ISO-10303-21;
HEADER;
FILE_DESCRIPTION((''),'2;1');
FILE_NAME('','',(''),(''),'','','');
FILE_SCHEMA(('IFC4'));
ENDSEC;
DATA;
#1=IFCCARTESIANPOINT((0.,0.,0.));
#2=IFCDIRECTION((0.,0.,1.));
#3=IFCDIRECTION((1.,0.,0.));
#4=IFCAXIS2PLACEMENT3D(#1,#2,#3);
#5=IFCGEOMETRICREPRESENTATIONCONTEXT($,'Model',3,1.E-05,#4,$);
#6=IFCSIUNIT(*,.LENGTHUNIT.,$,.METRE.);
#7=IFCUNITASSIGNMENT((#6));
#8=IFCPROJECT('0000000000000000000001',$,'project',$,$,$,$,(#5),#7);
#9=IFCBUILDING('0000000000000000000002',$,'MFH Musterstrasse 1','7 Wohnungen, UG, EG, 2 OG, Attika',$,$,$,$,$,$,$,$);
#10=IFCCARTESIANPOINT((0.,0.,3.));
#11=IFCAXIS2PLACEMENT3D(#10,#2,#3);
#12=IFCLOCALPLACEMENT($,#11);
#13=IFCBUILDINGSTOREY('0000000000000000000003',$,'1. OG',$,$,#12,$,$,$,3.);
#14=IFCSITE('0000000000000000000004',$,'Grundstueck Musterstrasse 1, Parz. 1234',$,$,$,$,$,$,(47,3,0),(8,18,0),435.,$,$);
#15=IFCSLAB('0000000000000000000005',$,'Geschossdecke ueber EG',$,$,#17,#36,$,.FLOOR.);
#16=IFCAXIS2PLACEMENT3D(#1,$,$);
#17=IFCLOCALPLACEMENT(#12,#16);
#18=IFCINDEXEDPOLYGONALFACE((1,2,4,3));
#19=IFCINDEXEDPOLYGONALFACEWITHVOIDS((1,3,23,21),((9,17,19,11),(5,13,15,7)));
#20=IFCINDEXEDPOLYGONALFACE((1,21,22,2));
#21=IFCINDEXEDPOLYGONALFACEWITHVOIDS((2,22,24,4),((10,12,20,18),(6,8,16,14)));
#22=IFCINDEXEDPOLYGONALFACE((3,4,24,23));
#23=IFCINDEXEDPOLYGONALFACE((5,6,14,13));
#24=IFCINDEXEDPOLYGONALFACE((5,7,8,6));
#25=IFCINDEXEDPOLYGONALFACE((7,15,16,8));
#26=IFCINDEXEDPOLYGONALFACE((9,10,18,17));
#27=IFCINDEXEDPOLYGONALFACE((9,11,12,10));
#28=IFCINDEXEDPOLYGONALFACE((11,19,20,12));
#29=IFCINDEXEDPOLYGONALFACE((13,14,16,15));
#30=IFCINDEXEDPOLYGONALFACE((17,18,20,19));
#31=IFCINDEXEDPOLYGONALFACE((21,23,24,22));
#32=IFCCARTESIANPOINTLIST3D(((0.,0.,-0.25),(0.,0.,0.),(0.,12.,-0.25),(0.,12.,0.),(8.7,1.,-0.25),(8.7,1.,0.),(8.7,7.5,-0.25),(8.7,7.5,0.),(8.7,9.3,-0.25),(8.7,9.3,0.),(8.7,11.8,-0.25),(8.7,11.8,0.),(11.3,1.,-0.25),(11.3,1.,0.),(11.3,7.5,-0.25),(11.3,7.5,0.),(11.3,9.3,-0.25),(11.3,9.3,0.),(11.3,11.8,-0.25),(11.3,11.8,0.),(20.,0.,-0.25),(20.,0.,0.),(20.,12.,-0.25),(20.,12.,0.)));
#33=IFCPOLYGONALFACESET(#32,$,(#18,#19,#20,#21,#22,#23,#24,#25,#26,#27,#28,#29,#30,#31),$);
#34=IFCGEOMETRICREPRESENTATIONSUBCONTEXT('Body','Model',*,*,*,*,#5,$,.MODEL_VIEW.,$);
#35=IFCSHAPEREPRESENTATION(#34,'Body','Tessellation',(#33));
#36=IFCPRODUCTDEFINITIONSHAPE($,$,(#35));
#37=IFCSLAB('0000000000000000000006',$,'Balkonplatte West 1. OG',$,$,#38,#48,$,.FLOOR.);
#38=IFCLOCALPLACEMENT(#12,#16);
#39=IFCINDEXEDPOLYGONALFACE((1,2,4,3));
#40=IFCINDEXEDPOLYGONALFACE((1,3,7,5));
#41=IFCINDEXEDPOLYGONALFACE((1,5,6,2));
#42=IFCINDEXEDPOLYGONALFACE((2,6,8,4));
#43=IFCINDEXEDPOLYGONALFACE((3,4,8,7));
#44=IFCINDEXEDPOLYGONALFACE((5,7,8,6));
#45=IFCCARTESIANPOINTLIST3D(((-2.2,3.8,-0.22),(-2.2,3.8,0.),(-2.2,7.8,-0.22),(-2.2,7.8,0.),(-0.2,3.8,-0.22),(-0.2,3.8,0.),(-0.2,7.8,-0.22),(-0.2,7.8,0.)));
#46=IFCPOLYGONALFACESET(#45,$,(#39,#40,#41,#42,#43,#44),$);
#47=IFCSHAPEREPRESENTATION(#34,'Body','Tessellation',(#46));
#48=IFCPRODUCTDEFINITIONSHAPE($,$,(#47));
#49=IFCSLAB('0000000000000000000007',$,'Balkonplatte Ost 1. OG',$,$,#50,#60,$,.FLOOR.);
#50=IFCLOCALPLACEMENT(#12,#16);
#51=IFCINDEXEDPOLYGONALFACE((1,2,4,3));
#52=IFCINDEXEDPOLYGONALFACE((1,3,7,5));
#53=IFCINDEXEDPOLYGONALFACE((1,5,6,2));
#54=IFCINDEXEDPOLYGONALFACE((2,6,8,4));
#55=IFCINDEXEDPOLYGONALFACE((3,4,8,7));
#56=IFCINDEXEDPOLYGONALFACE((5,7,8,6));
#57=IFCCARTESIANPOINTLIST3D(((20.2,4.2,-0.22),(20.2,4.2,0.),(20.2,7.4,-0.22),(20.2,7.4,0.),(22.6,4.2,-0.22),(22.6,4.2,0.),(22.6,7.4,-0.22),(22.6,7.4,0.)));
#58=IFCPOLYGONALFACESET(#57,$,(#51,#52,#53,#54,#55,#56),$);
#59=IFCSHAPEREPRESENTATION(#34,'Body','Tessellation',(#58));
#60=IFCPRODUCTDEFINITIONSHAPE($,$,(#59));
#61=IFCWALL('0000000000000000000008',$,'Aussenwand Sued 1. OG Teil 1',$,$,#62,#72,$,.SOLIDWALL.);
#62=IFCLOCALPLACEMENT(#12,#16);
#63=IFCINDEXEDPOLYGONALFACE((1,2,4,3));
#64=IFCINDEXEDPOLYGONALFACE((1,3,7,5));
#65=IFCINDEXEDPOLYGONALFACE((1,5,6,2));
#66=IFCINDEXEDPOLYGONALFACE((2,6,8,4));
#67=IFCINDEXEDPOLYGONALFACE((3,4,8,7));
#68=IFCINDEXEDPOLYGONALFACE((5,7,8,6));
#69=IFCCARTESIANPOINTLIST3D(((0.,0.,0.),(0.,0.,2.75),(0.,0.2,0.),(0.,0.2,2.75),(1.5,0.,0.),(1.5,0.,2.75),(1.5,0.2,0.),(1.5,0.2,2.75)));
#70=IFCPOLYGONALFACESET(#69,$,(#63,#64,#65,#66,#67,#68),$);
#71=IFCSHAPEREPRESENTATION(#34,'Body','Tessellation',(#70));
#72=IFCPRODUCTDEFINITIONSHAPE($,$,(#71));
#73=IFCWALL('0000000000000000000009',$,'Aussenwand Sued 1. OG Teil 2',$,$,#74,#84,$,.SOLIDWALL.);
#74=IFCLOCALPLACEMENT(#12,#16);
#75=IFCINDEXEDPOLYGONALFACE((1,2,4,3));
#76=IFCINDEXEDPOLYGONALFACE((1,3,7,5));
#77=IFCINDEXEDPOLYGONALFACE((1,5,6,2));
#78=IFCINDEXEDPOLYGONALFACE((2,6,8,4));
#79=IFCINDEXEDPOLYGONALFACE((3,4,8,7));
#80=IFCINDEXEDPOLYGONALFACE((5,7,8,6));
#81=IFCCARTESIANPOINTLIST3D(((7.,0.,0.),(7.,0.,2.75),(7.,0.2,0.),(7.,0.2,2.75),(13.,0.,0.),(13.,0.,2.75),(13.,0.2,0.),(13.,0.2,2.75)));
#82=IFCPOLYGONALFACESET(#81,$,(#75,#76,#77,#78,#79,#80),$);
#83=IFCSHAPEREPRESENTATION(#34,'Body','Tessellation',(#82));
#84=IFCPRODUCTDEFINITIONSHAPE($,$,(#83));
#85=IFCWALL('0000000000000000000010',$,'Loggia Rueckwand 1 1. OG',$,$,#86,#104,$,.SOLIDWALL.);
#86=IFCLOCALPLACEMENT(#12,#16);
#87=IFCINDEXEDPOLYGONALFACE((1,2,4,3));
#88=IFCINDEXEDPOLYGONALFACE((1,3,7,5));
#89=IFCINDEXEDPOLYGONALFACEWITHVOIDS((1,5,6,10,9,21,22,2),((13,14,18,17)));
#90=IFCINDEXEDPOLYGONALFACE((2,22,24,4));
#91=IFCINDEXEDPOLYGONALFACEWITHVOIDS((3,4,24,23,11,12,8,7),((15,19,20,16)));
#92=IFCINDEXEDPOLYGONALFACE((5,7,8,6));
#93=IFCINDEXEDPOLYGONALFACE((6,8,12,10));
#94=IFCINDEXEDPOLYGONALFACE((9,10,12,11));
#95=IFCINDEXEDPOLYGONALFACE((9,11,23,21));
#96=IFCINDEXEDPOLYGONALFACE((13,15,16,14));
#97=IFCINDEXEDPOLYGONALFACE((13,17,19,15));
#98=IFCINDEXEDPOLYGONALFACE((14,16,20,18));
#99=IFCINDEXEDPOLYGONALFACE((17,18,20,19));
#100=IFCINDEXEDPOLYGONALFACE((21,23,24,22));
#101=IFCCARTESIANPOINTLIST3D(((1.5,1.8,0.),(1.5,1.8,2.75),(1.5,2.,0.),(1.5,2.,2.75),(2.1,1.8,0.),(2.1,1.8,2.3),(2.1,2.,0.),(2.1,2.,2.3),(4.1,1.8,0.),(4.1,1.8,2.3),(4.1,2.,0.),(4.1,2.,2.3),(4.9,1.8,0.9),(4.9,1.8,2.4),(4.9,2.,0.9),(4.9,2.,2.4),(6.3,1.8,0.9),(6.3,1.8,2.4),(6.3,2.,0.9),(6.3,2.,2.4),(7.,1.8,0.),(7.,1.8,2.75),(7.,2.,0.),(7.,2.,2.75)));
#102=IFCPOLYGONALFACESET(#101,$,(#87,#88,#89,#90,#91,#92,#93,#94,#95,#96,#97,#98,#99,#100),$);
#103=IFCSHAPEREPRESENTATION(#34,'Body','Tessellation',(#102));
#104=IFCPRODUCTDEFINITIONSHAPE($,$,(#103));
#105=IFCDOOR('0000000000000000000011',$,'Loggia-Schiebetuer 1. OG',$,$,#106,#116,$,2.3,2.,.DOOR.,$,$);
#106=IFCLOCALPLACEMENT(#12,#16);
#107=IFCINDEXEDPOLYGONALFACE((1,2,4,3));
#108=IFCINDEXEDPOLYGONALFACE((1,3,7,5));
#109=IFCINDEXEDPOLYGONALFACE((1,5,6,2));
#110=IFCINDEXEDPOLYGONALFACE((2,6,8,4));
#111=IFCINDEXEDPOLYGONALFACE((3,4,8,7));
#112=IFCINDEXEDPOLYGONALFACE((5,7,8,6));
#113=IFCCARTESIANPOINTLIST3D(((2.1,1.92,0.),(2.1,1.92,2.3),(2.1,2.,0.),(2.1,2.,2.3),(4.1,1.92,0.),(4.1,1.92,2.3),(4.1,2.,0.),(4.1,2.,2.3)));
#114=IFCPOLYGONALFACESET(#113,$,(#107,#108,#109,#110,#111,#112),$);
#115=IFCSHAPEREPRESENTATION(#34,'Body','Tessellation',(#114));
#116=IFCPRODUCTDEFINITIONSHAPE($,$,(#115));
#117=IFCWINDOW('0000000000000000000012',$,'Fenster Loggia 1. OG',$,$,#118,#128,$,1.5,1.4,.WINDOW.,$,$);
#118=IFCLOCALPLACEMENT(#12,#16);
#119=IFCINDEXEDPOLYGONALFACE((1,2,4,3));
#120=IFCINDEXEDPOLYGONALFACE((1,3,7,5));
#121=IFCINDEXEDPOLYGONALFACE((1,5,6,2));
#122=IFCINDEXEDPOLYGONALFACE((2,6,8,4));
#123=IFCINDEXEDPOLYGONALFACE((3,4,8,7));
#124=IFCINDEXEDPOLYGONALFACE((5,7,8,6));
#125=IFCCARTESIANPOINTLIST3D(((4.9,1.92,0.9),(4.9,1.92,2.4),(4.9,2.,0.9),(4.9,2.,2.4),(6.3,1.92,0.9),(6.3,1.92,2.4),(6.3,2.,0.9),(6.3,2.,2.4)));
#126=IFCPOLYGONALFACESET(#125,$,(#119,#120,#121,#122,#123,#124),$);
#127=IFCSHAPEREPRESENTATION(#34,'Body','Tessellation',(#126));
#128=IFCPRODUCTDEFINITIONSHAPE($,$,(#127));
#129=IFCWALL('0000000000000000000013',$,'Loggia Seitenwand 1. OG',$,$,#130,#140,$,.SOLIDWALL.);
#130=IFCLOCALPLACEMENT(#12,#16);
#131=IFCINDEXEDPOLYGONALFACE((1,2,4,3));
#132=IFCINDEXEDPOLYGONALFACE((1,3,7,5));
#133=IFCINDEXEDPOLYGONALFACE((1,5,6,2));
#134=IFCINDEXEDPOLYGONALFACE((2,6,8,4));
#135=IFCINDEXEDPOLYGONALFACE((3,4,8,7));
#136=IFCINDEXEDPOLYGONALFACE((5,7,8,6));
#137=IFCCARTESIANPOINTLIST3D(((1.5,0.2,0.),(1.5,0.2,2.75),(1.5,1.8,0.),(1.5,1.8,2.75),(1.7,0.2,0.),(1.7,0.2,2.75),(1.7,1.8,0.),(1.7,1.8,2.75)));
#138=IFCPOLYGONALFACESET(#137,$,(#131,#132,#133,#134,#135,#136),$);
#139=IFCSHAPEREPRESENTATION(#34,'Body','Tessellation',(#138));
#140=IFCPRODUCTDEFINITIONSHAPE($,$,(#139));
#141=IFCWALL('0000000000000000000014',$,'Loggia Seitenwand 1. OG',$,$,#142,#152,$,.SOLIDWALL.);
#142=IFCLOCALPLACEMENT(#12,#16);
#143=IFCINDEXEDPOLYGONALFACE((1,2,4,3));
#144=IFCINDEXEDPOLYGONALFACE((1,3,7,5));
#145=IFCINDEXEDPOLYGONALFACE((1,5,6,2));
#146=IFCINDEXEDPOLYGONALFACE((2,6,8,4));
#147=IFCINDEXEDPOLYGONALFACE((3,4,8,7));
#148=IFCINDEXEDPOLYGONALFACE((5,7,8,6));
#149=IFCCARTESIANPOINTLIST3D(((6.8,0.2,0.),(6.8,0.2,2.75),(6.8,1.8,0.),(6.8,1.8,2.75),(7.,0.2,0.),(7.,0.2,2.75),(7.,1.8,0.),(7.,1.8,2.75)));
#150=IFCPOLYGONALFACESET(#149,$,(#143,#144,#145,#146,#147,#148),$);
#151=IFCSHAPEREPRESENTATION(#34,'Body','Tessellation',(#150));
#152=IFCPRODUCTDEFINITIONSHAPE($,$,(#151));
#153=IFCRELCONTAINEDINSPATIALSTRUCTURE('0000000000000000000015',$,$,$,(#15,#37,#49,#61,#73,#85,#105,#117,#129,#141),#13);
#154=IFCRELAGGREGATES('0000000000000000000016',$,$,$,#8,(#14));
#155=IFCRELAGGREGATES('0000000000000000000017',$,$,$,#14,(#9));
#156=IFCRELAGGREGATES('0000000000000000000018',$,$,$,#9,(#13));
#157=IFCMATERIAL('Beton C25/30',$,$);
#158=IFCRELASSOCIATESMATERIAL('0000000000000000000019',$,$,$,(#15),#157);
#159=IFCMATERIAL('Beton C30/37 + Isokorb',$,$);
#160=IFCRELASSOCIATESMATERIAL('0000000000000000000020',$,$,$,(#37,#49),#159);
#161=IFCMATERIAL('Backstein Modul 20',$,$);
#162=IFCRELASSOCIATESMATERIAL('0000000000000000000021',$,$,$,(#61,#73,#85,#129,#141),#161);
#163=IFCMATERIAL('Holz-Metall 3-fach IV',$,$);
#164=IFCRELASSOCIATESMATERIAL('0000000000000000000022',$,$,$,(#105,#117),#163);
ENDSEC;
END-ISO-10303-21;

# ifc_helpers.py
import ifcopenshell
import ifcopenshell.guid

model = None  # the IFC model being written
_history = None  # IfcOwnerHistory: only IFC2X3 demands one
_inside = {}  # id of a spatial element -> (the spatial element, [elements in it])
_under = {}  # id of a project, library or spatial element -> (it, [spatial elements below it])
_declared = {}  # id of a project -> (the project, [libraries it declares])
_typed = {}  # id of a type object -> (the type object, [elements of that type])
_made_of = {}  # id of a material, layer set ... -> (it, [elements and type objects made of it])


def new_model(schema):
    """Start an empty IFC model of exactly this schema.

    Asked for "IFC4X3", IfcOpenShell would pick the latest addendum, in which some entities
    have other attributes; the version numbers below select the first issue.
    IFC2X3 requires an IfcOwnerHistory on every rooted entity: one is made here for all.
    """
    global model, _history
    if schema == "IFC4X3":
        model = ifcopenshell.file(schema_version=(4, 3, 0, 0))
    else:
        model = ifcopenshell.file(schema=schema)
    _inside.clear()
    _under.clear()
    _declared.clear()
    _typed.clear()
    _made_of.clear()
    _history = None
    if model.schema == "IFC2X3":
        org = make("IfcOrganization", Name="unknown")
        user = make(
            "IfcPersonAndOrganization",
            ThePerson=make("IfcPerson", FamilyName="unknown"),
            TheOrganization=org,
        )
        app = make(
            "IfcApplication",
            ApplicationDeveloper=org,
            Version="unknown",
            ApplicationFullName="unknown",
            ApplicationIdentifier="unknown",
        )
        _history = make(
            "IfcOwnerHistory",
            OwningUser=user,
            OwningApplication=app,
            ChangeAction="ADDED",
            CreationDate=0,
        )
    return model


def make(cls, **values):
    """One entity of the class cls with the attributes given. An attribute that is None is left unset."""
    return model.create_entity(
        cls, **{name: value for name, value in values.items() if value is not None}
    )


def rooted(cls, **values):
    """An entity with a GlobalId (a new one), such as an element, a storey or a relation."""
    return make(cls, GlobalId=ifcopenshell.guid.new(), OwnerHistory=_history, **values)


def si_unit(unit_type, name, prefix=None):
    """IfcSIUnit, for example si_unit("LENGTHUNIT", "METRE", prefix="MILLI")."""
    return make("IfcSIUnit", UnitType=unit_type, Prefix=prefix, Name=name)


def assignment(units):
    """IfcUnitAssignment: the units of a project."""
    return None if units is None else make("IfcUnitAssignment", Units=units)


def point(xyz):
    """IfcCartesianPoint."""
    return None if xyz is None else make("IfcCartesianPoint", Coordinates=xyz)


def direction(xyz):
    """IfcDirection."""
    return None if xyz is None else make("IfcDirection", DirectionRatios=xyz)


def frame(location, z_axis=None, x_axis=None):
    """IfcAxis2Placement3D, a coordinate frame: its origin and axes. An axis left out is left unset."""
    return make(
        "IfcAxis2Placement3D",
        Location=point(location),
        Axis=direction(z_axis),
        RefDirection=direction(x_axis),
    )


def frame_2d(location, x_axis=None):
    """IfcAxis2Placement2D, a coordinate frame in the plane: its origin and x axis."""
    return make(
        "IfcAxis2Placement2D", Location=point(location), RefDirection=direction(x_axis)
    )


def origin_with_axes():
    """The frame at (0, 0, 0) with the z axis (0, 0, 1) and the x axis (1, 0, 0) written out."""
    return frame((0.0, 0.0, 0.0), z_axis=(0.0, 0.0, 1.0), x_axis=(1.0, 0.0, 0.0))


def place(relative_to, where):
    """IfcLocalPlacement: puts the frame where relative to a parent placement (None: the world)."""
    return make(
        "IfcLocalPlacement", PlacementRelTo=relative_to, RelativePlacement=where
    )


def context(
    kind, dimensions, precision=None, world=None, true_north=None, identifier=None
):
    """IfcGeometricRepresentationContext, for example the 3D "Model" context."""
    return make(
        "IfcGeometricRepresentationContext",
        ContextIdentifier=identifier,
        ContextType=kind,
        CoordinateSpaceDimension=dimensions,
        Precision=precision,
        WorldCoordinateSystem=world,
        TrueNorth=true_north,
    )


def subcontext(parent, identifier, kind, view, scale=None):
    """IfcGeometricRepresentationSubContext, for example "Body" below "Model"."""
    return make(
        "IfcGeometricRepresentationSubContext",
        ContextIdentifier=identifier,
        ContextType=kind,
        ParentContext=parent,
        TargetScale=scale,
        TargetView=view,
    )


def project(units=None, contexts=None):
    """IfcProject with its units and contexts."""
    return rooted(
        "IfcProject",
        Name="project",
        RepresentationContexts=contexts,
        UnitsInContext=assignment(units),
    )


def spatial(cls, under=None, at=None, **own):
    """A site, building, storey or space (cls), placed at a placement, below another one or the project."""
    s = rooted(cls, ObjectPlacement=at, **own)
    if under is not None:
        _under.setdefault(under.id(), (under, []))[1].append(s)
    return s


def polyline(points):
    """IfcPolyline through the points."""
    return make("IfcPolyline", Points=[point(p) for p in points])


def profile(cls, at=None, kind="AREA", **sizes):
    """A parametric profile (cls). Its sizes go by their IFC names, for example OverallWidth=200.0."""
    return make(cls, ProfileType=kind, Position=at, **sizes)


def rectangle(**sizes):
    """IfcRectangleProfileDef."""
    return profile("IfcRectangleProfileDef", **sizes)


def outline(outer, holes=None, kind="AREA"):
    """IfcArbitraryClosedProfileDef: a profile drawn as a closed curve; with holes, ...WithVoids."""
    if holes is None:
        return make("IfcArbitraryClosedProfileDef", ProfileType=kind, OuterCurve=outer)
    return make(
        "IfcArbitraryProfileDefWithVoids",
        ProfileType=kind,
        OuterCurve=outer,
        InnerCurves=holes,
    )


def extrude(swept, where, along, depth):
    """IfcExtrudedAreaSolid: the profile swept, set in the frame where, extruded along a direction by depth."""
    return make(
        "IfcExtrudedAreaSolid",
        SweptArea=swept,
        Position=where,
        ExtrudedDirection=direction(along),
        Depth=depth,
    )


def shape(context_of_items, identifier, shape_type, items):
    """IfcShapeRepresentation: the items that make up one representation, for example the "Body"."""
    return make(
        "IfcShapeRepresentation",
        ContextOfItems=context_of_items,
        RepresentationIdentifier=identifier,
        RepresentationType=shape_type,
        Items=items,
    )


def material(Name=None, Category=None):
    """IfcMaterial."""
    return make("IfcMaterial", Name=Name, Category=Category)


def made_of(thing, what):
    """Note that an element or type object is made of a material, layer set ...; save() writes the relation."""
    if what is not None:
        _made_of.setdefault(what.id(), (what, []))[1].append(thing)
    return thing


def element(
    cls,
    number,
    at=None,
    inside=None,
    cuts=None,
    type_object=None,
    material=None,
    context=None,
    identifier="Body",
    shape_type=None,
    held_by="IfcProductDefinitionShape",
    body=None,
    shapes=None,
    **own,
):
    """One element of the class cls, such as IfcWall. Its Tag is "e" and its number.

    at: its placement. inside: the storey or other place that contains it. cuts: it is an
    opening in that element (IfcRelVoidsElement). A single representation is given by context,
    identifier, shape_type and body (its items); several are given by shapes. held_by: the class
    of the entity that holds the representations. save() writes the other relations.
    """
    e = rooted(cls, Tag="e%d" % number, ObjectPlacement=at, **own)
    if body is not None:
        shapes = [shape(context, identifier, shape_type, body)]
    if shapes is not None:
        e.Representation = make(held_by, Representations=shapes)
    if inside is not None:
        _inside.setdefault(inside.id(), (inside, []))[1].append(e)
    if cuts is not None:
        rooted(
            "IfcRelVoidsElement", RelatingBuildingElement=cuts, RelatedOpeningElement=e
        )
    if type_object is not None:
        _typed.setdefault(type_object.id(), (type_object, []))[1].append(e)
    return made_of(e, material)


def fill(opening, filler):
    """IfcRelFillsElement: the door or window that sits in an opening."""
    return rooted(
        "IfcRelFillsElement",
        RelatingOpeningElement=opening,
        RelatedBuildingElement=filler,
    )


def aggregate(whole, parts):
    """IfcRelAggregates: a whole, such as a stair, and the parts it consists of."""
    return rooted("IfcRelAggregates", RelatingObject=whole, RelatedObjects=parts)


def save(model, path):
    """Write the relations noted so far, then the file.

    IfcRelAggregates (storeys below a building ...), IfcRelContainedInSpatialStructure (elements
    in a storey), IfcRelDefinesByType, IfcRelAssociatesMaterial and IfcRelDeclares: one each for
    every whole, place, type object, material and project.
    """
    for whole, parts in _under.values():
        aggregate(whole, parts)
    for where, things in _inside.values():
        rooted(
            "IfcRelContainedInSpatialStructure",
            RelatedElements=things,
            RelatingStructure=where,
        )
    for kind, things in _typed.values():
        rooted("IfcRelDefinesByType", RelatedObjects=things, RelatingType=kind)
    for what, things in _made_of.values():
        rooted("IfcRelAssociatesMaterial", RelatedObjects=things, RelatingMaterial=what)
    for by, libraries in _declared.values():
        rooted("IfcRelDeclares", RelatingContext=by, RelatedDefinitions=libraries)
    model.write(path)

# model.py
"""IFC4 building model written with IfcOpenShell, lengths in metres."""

from ifc_helpers import new_model, si_unit, frame, frame_2d, origin_with_axes, place, context, subcontext, project, spatial, polyline, rectangle, outline, extrude, material, element, fill, save


model = new_model("IFC4")

# Units and contexts
model_context = context("Model", 3, precision=1e-05, world=origin_with_axes())
body_context = subcontext(model_context, "Body", "Model", "MODEL_VIEW")
ifc_project = project(units=[si_unit("LENGTHUNIT", "METRE")], contexts=[model_context])

# Site, building, storey
site = spatial("IfcSite", under=ifc_project, Name="Grundstueck Musterstrasse 1, Parz. 1234", RefLatitude=(47, 3, 0), RefLongitude=(8, 18, 0), RefElevation=435.0)
building = spatial("IfcBuilding", under=site, Name="MFH Musterstrasse 1", Description="7 Wohnungen, UG, EG, 2 OG, Attika")
storey_placement = place(None, frame((0.0, 0.0, 3.0), z_axis=(0.0, 0.0, 1.0), x_axis=(1.0, 0.0, 0.0)))
storey = spatial("IfcBuildingStorey", under=building, at=storey_placement, Name="1. OG", Elevation=3.0)

# Slab, openings
ifc_material_1 = material(Name="Beton C25/30")
slab_1_placement = place(storey_placement, frame((0.0, 0.0, -0.25), z_axis=(0.0, 0.0, 1.0), x_axis=(1.0, 0.0, 0.0)))
slab_1 = element("IfcSlab", 1, at=slab_1_placement, inside=storey, material=ifc_material_1, Name="Geschossdecke ueber EG", PredefinedType="FLOOR", context=body_context, shape_type="SweptSolid", body=[
    extrude(outline(polyline([(0.0, 0.0), (20.0, 0.0), (20.0, 12.0), (0.0, 12.0), (0.0, 0.0)])), origin_with_axes(), (0.0, 0.0, 1.0), 0.25),
])
opening_1_placement = place(slab_1_placement, frame((8.7, 1.0, -0.01), z_axis=(0.0, 0.0, 1.0), x_axis=(1.0, 0.0, 0.0)))
element("IfcOpeningElement", 2, at=opening_1_placement, cuts=slab_1, context=body_context, shape_type="SweptSolid", body=[
    extrude(rectangle(XDim=2.6, YDim=6.5, at=frame_2d((1.3, 3.25))), origin_with_axes(), (0.0, 0.0, 1.0), 0.27),
])
opening_2_placement = place(slab_1_placement, frame((8.7, 9.3, -0.01), z_axis=(0.0, 0.0, 1.0), x_axis=(1.0, 0.0, 0.0)))
element("IfcOpeningElement", 3, at=opening_2_placement, cuts=slab_1, context=body_context, shape_type="SweptSolid", body=[
    extrude(rectangle(XDim=2.6, YDim=2.5, at=frame_2d((1.3, 1.25))), origin_with_axes(), (0.0, 0.0, 1.0), 0.27),
])

# Slabs
ifc_material_2 = material(Name="Beton C30/37 + Isokorb")
slab_2_placement = place(storey_placement, frame((0.0, 0.0, -0.22), z_axis=(0.0, 0.0, 1.0), x_axis=(1.0, 0.0, 0.0)))
element("IfcSlab", 4, at=slab_2_placement, inside=storey, material=ifc_material_2, Name="Balkonplatte West 1. OG", PredefinedType="FLOOR", context=body_context, shape_type="SweptSolid", body=[
    extrude(outline(polyline([(-2.2, 3.8), (-0.2, 3.8), (-0.2, 7.8), (-2.2, 7.8), (-2.2, 3.8)])), origin_with_axes(), (0.0, 0.0, 1.0), 0.22),
])
slab_3_placement = place(storey_placement, frame((0.0, 0.0, -0.22), z_axis=(0.0, 0.0, 1.0), x_axis=(1.0, 0.0, 0.0)))
element("IfcSlab", 5, at=slab_3_placement, inside=storey, material=ifc_material_2, Name="Balkonplatte Ost 1. OG", PredefinedType="FLOOR", context=body_context, shape_type="SweptSolid", body=[
    extrude(outline(polyline([(20.2, 4.2), (22.6, 4.2), (22.6, 7.4), (20.2, 7.4), (20.2, 4.2)])), origin_with_axes(), (0.0, 0.0, 1.0), 0.22),
])

# Walls
ifc_material_3 = material(Name="Backstein Modul 20")
wall_1_placement = place(storey_placement, origin_with_axes())
element("IfcWall", 6, at=wall_1_placement, inside=storey, material=ifc_material_3, Name="Aussenwand Sued 1. OG Teil 1", PredefinedType="SOLIDWALL", context=body_context, shape_type="SweptSolid", body=[
    extrude(rectangle(XDim=1.5, YDim=0.2, at=frame_2d((0.75, 0.1))), origin_with_axes(), (0.0, 0.0, 1.0), 2.75),
])
wall_2_placement = place(storey_placement, frame((7.0, 0.0, 0.0), z_axis=(0.0, 0.0, 1.0), x_axis=(1.0, 0.0, 0.0)))
element("IfcWall", 7, at=wall_2_placement, inside=storey, material=ifc_material_3, Name="Aussenwand Sued 1. OG Teil 2", PredefinedType="SOLIDWALL", context=body_context, shape_type="SweptSolid", body=[
    extrude(rectangle(XDim=6.0, YDim=0.2, at=frame_2d((3.0, 0.1))), origin_with_axes(), (0.0, 0.0, 1.0), 2.75),
])

# Wall, openings, door, window
wall_3_placement = place(storey_placement, frame((1.5, 1.8, 0.0), z_axis=(0.0, 0.0, 1.0), x_axis=(1.0, 0.0, 0.0)))
wall_3 = element("IfcWall", 8, at=wall_3_placement, inside=storey, material=ifc_material_3, Name="Loggia Rueckwand 1 1. OG", PredefinedType="SOLIDWALL", context=body_context, shape_type="SweptSolid", body=[
    extrude(rectangle(XDim=5.5, YDim=0.2, at=frame_2d((2.75, 0.1))), origin_with_axes(), (0.0, 0.0, 1.0), 2.75),
])
opening_3_placement = place(wall_3_placement, frame((0.6, -0.21, 0.0), z_axis=(0.0, 0.0, 1.0), x_axis=(1.0, 0.0, 0.0)))
opening_3 = element("IfcOpeningElement", 9, at=opening_3_placement, cuts=wall_3, context=body_context, shape_type="SweptSolid", body=[
    extrude(rectangle(XDim=2.0, YDim=0.42, at=frame_2d((1.0, 0.21))), origin_with_axes(), (0.0, 0.0, 1.0), 2.3),
])
opening_4_placement = place(wall_3_placement, frame((3.4, -0.21, 0.9), z_axis=(0.0, 0.0, 1.0), x_axis=(1.0, 0.0, 0.0)))
opening_4 = element("IfcOpeningElement", 10, at=opening_4_placement, cuts=wall_3, context=body_context, shape_type="SweptSolid", body=[
    extrude(rectangle(XDim=1.4, YDim=0.42, at=frame_2d((0.7, 0.21))), origin_with_axes(), (0.0, 0.0, 1.0), 1.5),
])
ifc_material_4 = material(Name="Holz-Metall 3-fach IV")
door_1_placement = place(storey_placement, frame((2.1, 1.92, 0.0), z_axis=(0.0, 0.0, 1.0), x_axis=(1.0, 0.0, 0.0)))
door_1 = element("IfcDoor", 11, at=door_1_placement, inside=storey, material=ifc_material_4, Name="Loggia-Schiebetuer 1. OG", OverallHeight=2.3, OverallWidth=2.0, PredefinedType="DOOR", context=body_context, shape_type="SweptSolid", body=[
    extrude(rectangle(XDim=2.0, YDim=0.08, at=frame_2d((1.0, 0.04))), origin_with_axes(), (0.0, 0.0, 1.0), 2.3),
])
fill(opening_3, door_1)
window_1_placement = place(storey_placement, frame((4.9, 1.92, 0.9), z_axis=(0.0, 0.0, 1.0), x_axis=(1.0, 0.0, 0.0)))
window_1 = element("IfcWindow", 12, at=window_1_placement, inside=storey, material=ifc_material_4, Name="Fenster Loggia 1. OG", OverallHeight=1.5, OverallWidth=1.4, PredefinedType="WINDOW", context=body_context, shape_type="SweptSolid", body=[
    extrude(rectangle(XDim=1.4, YDim=0.08, at=frame_2d((0.7, 0.04))), origin_with_axes(), (0.0, 0.0, 1.0), 1.5),
])
fill(opening_4, window_1)

# Walls
for number, where, z_axis, x_axis, name in (
    (13, (1.5, 0.2, 0.0), (0.0, 0.0, 1.0), (1.0, 0.0, 0.0), "Loggia Seitenwand 1. OG"),
    (14, (6.8, 0.2, 0.0), (0.0, 0.0, 1.0), (1.0, 0.0, 0.0), "Loggia Seitenwand 1. OG"),
):
    element("IfcWall", number, at=place(storey_placement, frame(where, z_axis=z_axis, x_axis=x_axis)), inside=storey, material=ifc_material_3, Name=name, PredefinedType="SOLIDWALL", context=body_context, shape_type="SweptSolid", body=[
        extrude(rectangle(XDim=0.2, YDim=1.6, at=frame_2d((0.1, 0.8))), origin_with_axes(), (0.0, 0.0, 1.0), 2.75),
    ])

save(model, "model.ifc")
